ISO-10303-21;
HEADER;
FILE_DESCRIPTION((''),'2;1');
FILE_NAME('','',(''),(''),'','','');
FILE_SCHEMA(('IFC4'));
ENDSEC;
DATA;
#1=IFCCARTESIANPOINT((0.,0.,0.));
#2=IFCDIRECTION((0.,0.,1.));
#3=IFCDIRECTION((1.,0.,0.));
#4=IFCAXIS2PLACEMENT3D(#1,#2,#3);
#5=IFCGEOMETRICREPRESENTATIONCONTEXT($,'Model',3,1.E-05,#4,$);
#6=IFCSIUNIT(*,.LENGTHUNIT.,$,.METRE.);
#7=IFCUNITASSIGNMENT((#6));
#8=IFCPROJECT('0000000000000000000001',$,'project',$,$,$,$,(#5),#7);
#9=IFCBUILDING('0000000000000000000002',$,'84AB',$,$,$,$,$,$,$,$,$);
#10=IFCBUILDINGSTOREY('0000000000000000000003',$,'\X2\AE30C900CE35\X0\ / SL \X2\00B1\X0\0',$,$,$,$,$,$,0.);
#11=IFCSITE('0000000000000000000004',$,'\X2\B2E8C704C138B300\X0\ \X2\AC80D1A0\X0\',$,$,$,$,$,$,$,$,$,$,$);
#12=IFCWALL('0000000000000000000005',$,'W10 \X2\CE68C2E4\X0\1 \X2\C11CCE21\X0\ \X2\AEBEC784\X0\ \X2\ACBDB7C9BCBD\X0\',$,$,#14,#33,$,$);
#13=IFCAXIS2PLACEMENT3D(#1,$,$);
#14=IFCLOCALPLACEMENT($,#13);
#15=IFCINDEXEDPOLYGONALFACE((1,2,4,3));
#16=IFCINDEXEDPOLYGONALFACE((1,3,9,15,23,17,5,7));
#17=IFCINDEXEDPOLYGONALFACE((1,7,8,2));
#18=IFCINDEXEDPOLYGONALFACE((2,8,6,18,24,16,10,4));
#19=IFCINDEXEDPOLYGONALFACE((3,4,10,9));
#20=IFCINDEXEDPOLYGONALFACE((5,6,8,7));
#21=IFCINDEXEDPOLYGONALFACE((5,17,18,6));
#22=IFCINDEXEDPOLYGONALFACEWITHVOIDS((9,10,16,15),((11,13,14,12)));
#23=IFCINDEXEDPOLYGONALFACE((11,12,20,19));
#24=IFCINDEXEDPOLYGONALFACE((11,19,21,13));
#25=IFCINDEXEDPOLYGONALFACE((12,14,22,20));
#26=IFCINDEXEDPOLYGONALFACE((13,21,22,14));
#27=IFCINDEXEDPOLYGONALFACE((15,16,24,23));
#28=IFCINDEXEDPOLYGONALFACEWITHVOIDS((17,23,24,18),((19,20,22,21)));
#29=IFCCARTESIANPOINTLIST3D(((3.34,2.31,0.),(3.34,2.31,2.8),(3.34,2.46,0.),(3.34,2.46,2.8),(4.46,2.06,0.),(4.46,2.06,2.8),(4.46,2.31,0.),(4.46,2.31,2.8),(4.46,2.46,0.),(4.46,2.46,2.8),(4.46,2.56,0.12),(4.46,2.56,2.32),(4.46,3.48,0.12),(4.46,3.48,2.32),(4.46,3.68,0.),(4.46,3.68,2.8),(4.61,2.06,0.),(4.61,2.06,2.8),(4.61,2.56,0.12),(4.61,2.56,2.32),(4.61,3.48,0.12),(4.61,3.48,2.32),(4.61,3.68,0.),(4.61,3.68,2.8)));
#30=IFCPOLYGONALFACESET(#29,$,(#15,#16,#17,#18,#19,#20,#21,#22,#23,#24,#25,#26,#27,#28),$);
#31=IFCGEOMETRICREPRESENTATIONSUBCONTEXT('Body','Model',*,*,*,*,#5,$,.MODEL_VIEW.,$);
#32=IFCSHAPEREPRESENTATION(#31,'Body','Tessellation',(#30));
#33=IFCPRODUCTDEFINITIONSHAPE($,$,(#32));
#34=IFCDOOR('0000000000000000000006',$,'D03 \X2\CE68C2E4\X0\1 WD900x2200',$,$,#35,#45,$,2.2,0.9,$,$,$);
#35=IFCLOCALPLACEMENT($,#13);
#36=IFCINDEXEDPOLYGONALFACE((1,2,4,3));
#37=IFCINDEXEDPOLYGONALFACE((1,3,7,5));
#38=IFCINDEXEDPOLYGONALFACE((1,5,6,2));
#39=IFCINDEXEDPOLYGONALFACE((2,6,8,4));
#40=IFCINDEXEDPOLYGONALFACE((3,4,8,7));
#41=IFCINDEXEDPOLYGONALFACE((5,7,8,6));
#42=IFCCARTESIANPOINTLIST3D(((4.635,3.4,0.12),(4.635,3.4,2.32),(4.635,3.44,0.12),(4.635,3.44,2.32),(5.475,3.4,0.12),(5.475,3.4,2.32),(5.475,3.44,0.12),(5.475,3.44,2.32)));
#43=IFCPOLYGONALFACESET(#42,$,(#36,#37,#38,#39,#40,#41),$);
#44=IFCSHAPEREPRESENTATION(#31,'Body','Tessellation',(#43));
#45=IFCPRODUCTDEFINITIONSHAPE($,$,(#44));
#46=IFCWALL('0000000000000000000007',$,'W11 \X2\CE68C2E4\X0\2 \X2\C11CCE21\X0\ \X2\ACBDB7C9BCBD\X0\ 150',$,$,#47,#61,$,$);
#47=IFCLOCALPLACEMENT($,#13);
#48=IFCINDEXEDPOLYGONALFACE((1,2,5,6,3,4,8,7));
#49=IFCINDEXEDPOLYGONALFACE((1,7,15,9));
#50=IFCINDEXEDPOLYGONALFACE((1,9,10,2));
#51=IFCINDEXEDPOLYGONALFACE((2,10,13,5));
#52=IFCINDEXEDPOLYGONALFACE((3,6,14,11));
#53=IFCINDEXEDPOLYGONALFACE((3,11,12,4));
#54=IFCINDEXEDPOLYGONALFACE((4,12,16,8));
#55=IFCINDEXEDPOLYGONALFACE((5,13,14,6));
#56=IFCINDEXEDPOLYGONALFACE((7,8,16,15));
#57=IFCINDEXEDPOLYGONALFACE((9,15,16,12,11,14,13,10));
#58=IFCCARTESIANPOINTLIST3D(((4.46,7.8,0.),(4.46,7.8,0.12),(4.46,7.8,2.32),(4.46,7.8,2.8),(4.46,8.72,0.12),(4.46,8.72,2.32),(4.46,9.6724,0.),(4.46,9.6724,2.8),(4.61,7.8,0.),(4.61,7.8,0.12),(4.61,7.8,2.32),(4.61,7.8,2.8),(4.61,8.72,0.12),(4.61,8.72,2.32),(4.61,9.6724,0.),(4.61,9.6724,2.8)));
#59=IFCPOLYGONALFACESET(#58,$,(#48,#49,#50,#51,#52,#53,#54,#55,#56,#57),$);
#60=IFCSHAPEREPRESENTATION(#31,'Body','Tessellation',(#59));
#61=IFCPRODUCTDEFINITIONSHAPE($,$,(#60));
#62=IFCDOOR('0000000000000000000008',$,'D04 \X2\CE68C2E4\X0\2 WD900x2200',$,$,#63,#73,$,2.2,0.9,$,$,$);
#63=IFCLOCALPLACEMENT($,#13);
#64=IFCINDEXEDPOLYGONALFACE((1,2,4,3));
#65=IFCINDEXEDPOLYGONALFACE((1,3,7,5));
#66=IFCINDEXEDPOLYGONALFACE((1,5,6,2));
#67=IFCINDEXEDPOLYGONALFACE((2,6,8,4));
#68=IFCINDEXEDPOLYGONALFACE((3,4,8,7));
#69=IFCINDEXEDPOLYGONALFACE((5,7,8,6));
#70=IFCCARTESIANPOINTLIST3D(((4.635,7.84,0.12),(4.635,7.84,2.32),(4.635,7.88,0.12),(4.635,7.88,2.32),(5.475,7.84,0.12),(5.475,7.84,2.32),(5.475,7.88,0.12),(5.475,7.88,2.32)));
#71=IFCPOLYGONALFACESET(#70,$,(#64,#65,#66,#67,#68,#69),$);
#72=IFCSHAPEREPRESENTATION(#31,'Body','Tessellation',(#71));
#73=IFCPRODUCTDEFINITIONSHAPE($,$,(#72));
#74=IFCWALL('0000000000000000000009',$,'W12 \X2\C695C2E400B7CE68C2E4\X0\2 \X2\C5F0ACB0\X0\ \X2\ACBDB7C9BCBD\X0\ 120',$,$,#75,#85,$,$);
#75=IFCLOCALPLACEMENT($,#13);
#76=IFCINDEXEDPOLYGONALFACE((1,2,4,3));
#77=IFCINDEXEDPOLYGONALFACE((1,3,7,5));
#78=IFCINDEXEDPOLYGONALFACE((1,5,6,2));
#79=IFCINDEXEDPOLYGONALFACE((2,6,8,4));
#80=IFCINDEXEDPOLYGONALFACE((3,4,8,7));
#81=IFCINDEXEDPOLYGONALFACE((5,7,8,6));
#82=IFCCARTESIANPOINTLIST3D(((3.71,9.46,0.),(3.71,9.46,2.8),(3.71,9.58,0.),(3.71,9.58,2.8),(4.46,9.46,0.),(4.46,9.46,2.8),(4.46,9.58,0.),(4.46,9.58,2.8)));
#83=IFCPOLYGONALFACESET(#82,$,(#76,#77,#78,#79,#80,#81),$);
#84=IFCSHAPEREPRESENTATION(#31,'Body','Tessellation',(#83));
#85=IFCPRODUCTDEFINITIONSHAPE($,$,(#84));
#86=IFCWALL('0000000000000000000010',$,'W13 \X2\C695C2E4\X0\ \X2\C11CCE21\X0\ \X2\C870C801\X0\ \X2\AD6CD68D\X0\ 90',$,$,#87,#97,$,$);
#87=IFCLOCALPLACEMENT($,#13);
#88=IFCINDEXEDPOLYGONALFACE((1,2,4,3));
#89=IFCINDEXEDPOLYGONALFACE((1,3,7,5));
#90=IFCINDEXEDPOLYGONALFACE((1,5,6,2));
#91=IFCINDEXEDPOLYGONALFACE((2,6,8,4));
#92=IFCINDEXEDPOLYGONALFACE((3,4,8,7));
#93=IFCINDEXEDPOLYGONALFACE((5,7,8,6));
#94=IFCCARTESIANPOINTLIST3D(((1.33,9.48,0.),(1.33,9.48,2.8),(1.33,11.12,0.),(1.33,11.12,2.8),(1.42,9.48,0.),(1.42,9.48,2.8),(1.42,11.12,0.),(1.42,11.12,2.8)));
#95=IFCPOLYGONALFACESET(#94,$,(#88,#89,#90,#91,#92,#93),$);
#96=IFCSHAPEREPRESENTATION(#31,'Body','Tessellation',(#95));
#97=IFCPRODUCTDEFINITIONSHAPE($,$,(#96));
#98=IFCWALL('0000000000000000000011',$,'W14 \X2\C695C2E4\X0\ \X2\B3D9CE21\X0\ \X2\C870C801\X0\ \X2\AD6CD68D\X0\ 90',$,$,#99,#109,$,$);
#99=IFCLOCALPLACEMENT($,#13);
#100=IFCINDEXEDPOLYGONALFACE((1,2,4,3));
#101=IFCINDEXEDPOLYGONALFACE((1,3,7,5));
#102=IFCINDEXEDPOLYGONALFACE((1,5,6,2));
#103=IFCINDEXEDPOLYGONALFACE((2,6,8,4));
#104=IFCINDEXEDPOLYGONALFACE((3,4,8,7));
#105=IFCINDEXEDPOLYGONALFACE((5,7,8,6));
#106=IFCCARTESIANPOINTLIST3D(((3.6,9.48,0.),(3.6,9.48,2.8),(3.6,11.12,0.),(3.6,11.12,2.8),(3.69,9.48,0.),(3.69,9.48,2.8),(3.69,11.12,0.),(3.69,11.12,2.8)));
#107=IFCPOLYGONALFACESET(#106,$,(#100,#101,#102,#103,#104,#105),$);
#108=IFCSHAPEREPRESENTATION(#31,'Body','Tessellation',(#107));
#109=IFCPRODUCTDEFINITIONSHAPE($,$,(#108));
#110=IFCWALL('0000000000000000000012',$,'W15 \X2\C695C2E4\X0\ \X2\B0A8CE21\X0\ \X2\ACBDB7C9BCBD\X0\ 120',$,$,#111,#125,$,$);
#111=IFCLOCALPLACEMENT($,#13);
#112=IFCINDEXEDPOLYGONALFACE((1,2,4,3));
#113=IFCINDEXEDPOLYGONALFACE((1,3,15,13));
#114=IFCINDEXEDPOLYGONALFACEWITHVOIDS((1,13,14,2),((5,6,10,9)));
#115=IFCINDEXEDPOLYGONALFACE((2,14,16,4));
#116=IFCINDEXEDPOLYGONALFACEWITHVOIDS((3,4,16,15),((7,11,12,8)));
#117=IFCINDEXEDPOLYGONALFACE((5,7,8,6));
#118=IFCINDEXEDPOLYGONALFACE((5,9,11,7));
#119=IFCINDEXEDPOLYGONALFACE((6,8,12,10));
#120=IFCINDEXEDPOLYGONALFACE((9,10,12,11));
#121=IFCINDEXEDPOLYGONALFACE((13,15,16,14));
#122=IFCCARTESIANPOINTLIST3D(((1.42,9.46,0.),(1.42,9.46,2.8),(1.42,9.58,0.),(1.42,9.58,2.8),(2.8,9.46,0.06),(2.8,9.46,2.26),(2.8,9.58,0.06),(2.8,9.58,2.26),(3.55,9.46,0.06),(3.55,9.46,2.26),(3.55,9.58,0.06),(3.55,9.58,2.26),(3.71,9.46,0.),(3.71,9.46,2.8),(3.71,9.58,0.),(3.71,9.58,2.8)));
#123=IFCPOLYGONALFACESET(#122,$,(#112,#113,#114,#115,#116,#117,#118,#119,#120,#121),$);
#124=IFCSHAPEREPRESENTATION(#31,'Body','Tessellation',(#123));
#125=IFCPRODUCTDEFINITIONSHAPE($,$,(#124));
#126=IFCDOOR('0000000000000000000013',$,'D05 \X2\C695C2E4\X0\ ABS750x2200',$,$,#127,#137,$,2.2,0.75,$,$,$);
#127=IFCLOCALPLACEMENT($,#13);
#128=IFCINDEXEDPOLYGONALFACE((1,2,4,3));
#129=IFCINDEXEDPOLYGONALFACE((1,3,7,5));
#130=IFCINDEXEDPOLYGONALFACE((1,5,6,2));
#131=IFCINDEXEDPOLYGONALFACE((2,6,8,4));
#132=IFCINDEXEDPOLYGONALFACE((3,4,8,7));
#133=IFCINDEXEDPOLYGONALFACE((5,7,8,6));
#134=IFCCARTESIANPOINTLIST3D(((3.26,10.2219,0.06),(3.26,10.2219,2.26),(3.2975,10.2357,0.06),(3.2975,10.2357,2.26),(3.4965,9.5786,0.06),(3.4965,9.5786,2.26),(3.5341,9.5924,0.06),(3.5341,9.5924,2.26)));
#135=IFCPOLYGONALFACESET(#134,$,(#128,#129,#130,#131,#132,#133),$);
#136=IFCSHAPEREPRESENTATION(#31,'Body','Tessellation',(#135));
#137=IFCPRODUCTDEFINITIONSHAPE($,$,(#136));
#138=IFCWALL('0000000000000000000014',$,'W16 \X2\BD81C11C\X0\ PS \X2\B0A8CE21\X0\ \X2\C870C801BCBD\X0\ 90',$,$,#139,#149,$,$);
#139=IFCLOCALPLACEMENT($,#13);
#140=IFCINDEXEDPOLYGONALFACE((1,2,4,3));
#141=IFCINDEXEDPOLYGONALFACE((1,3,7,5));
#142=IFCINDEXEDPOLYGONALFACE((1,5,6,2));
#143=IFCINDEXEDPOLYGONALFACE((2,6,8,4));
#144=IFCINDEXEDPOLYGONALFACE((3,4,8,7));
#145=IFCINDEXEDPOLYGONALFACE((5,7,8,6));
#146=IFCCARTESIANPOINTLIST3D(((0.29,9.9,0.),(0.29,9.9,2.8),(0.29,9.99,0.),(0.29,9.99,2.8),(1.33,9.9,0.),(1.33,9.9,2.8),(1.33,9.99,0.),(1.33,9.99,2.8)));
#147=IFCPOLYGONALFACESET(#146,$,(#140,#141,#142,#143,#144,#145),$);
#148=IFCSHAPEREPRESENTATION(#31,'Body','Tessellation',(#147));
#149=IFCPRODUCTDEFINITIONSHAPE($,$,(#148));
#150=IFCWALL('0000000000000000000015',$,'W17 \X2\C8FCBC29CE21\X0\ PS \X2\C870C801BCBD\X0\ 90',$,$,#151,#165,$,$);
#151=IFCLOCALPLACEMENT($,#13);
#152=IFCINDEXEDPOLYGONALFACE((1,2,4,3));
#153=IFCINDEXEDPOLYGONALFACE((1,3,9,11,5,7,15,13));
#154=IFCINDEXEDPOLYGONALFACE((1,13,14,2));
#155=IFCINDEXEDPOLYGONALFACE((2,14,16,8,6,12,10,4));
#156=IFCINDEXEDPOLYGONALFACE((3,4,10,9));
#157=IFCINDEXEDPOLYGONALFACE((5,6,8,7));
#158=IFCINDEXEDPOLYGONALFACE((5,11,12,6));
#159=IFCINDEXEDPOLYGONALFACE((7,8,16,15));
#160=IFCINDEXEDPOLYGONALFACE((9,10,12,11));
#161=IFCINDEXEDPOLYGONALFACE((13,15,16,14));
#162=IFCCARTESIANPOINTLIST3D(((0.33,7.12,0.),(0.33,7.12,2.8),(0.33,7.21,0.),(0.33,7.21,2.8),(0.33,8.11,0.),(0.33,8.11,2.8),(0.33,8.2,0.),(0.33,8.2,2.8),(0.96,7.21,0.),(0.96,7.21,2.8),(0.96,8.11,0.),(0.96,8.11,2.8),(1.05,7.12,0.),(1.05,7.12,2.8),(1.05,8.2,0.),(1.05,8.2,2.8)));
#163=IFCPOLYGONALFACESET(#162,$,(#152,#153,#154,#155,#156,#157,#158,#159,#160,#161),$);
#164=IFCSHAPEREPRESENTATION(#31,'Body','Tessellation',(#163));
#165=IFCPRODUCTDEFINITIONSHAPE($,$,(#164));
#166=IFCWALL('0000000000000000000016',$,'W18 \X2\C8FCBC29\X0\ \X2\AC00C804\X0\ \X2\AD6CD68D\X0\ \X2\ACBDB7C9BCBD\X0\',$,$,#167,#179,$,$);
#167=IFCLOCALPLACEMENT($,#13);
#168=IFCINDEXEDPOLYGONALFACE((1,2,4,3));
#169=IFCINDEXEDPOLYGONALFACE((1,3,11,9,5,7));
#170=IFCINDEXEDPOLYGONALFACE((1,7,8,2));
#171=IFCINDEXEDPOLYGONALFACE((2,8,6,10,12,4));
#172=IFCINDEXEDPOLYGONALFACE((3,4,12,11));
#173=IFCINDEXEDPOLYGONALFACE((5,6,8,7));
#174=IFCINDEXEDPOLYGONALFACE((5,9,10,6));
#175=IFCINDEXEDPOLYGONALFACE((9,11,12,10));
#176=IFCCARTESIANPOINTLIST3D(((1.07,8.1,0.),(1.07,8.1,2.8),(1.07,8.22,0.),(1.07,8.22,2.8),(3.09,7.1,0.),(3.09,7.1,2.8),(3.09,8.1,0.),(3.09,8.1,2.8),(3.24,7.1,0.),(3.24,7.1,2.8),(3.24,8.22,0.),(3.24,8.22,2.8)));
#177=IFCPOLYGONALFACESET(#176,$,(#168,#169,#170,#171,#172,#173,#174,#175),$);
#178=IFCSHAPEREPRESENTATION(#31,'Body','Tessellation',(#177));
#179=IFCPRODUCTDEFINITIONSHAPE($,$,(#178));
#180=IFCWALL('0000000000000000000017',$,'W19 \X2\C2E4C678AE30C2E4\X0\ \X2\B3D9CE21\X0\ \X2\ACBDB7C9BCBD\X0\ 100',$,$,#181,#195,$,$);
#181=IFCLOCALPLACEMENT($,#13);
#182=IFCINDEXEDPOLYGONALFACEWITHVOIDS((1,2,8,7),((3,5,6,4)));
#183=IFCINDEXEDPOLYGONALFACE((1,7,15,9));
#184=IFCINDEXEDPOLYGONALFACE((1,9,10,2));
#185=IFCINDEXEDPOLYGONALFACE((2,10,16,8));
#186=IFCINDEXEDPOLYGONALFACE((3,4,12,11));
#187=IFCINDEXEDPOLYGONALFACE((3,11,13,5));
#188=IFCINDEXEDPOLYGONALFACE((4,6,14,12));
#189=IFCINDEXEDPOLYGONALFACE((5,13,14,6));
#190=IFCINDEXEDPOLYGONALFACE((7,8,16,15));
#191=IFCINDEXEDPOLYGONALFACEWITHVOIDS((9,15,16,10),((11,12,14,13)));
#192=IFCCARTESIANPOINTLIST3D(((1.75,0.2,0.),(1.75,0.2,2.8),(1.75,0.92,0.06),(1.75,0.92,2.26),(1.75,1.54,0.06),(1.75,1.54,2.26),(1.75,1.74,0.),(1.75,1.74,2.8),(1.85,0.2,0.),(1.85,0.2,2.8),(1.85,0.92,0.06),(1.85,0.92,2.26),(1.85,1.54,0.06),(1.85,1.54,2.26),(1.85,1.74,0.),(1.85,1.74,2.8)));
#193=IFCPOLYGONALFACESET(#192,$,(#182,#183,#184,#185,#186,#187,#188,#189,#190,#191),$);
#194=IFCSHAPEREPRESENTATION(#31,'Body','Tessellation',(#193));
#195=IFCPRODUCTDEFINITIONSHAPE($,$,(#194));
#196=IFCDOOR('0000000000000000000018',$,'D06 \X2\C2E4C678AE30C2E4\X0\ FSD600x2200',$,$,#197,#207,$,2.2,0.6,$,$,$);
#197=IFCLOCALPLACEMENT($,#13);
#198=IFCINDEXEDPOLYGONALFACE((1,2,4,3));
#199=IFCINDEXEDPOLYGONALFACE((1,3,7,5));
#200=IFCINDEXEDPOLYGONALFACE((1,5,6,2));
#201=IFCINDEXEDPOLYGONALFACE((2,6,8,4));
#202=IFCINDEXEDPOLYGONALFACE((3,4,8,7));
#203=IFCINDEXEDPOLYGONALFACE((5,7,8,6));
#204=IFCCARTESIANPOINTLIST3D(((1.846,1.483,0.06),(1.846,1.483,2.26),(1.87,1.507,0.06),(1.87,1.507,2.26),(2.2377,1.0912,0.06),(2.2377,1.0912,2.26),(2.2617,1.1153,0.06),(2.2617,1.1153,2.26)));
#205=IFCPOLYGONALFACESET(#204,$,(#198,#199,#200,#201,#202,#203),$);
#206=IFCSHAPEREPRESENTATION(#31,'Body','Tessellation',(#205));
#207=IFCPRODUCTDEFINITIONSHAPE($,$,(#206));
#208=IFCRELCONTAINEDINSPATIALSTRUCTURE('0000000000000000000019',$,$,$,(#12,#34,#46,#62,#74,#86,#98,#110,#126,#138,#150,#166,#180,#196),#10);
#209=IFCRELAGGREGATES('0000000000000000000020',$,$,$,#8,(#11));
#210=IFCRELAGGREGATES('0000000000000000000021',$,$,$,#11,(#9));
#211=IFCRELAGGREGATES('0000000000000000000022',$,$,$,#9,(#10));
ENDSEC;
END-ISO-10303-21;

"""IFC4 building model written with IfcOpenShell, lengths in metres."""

from ifc_helpers import new_model, si_unit, frame, origin, origin_with_axes, place, context, subcontext, project, spatial, polyline, outline, extrude, element, fill, save


model = new_model("IFC4")

# Units and contexts
model_context = context("Model", 3, precision=1e-05, world=origin_with_axes())
body_context = subcontext(model_context, "Body", "Model", "MODEL_VIEW")
ifc_project = project(units=[si_unit("LENGTHUNIT", "METRE")], contexts=[model_context])

# Site, building, storey
site = spatial("IfcSite", under=ifc_project, Name="단위세대 검토")
building = spatial("IfcBuilding", under=site, Name="84AB")
storey = spatial("IfcBuildingStorey", under=building, Name="기준층 / SL ±0", Elevation=0.0)

# Walls, openings, doors
wall_1_placement = place(None, origin_with_axes())
wall_1 = element("IfcWall", 1, at=wall_1_placement, inside=storey, Name="W10 침실1 서측 꺾임 경량벽", context=body_context, shape_type="SweptSolid", body=[
    extrude(outline(polyline([(4.61, 2.31), (4.61, 2.06), (4.46, 2.06), (4.46, 2.31), (3.34, 2.31), (3.34, 2.46), (4.46, 2.46), (4.46, 3.68), (4.61, 3.68), (4.61, 2.46), (4.61, 2.31)])), origin(), (0.0, 0.0, 1.0), 2.8),
])
opening_1_placement = place(wall_1_placement, origin_with_axes())
opening_1 = element("IfcOpeningElement", 2, at=opening_1_placement, cuts=wall_1, context=body_context, shape_type="SweptSolid", body=[
    extrude(outline(polyline([(4.611, 2.56), (4.611, 3.48), (4.459, 3.48), (4.459, 2.56), (4.611, 2.56)])), frame((0.0, 0.0, 0.12)), (0.0, 0.0, 1.0), 2.2),
])
door_1_placement = place(None, origin_with_axes())
door_1 = element("IfcDoor", 3, at=door_1_placement, inside=storey, Name="D03 침실1 WD900x2200", OverallHeight=2.2, OverallWidth=0.9, context=body_context, shape_type="SweptSolid", body=[
    extrude(outline(polyline([(4.635, 3.4), (4.635, 3.44), (5.475, 3.44), (5.475, 3.4), (4.635, 3.4)])), frame((0.0, 0.0, 0.12)), (0.0, 0.0, 1.0), 2.2),
])
fill(opening_1, door_1)
wall_2_placement = place(None, origin_with_axes())
wall_2 = element("IfcWall", 4, at=wall_2_placement, inside=storey, Name="W11 침실2 서측 경량벽 150", context=body_context, shape_type="SweptSolid", body=[
    extrude(outline(polyline([(4.61, 7.8), (4.61, 9.6724), (4.46, 9.6724), (4.46, 7.8), (4.61, 7.8)])), origin(), (0.0, 0.0, 1.0), 2.8),
])
opening_2_placement = place(wall_2_placement, origin_with_axes())
opening_2 = element("IfcOpeningElement", 5, at=opening_2_placement, cuts=wall_2, context=body_context, shape_type="SweptSolid", body=[
    extrude(outline(polyline([(4.611, 7.8), (4.611, 8.72), (4.459, 8.72), (4.459, 7.8), (4.611, 7.8)])), frame((0.0, 0.0, 0.12)), (0.0, 0.0, 1.0), 2.2),
])
door_2_placement = place(None, origin_with_axes())
door_2 = element("IfcDoor", 6, at=door_2_placement, inside=storey, Name="D04 침실2 WD900x2200", OverallHeight=2.2, OverallWidth=0.9, context=body_context, shape_type="SweptSolid", body=[
    extrude(outline(polyline([(4.635, 7.88), (4.635, 7.84), (5.475, 7.84), (5.475, 7.88), (4.635, 7.88)])), frame((0.0, 0.0, 0.12)), (0.0, 0.0, 1.0), 2.2),
])
fill(opening_2, door_2)

# Walls
wall_3_placement = place(None, origin_with_axes())
element("IfcWall", 7, at=wall_3_placement, inside=storey, Name="W12 욕실·침실2 연결 경량벽 120", context=body_context, shape_type="SweptSolid", body=[
    extrude(outline(polyline([(4.46, 9.46), (4.46, 9.58), (3.71, 9.58), (3.71, 9.46), (4.46, 9.46)])), origin(), (0.0, 0.0, 1.0), 2.8),
])
wall_4_placement = place(None, origin_with_axes())
element("IfcWall", 8, at=wall_4_placement, inside=storey, Name="W13 욕실 서측 조적 구획 90", context=body_context, shape_type="SweptSolid", body=[
    extrude(outline(polyline([(1.42, 9.48), (1.42, 11.12), (1.33, 11.12), (1.33, 9.48), (1.42, 9.48)])), origin(), (0.0, 0.0, 1.0), 2.8),
])
wall_5_placement = place(None, origin_with_axes())
element("IfcWall", 9, at=wall_5_placement, inside=storey, Name="W14 욕실 동측 조적 구획 90", context=body_context, shape_type="SweptSolid", body=[
    extrude(outline(polyline([(3.69, 9.48), (3.69, 11.12), (3.6, 11.12), (3.6, 9.48), (3.69, 9.48)])), origin(), (0.0, 0.0, 1.0), 2.8),
])

# Wall, opening, door
wall_6_placement = place(None, origin_with_axes())
wall_6 = element("IfcWall", 10, at=wall_6_placement, inside=storey, Name="W15 욕실 남측 경량벽 120", context=body_context, shape_type="SweptSolid", body=[
    extrude(outline(polyline([(3.71, 9.46), (3.71, 9.58), (1.42, 9.58), (1.42, 9.46), (3.71, 9.46)])), origin(), (0.0, 0.0, 1.0), 2.8),
])
opening_3_placement = place(wall_6_placement, origin_with_axes())
opening_3 = element("IfcOpeningElement", 11, at=opening_3_placement, cuts=wall_6, context=body_context, shape_type="SweptSolid", body=[
    extrude(outline(polyline([(3.55, 9.459), (3.55, 9.581), (2.8, 9.581), (2.8, 9.459), (3.55, 9.459)])), frame((0.0, 0.0, 0.06)), (0.0, 0.0, 1.0), 2.2),
])
door_3_placement = place(None, origin_with_axes())
door_3 = element("IfcDoor", 12, at=door_3_placement, inside=storey, Name="D05 욕실 ABS750x2200", OverallHeight=2.2, OverallWidth=0.75, context=body_context, shape_type="SweptSolid", body=[
    extrude(outline(polyline([(3.26, 10.2219), (3.2975, 10.2357), (3.5341, 9.5924), (3.4965, 9.5786), (3.26, 10.2219)])), frame((0.0, 0.0, 0.06)), (0.0, 0.0, 1.0), 2.2),
])
fill(opening_3, door_3)

# Walls
wall_7_placement = place(None, origin_with_axes())
element("IfcWall", 13, at=wall_7_placement, inside=storey, Name="W16 북서 PS 남측 조적벽 90", context=body_context, shape_type="SweptSolid", body=[
    extrude(outline(polyline([(1.33, 9.9), (1.33, 9.99), (0.29, 9.99), (0.29, 9.9), (1.33, 9.9)])), origin(), (0.0, 0.0, 1.0), 2.8),
])
wall_8_placement = place(None, origin_with_axes())
element("IfcWall", 14, at=wall_8_placement, inside=storey, Name="W17 주방측 PS 조적벽 90", context=body_context, shape_type="SweptSolid", body=[
    extrude(outline(polyline([(0.33, 7.12), (1.05, 7.12), (1.05, 8.2), (0.33, 8.2), (0.33, 8.11), (0.96, 8.11), (0.96, 7.21), (0.33, 7.21), (0.33, 7.12)])), origin(), (0.0, 0.0, 1.0), 2.8),
])
wall_9_placement = place(None, origin_with_axes())
element("IfcWall", 15, at=wall_9_placement, inside=storey, Name="W18 주방 가전 구획 경량벽", context=body_context, shape_type="SweptSolid", body=[
    extrude(outline(polyline([(1.07, 8.1), (3.09, 8.1), (3.09, 7.1), (3.24, 7.1), (3.24, 8.22), (1.07, 8.22), (1.07, 8.1)])), origin(), (0.0, 0.0, 1.0), 2.8),
])

# Wall, opening, door
wall_10_placement = place(None, origin_with_axes())
wall_10 = element("IfcWall", 16, at=wall_10_placement, inside=storey, Name="W19 실외기실 동측 경량벽 100", context=body_context, shape_type="SweptSolid", body=[
    extrude(outline(polyline([(1.85, 0.2), (1.85, 1.74), (1.75, 1.74), (1.75, 0.2), (1.85, 0.2)])), origin(), (0.0, 0.0, 1.0), 2.8),
])
opening_4_placement = place(wall_10_placement, origin_with_axes())
opening_4 = element("IfcOpeningElement", 17, at=opening_4_placement, cuts=wall_10, context=body_context, shape_type="SweptSolid", body=[
    extrude(outline(polyline([(1.851, 0.92), (1.851, 1.54), (1.749, 1.54), (1.749, 0.92), (1.851, 0.92)])), frame((0.0, 0.0, 0.06)), (0.0, 0.0, 1.0), 2.2),
])
door_4_placement = place(None, origin_with_axes())
door_4 = element("IfcDoor", 18, at=door_4_placement, inside=storey, Name="D06 실외기실 FSD600x2200", OverallHeight=2.2, OverallWidth=0.6, context=body_context, shape_type="SweptSolid", body=[
    extrude(outline(polyline([(1.846, 1.483), (1.87, 1.507), (2.2617, 1.1153), (2.2377, 1.0912), (1.846, 1.483)])), frame((0.0, 0.0, 0.06)), (0.0, 0.0, 1.0), 2.2),
])
fill(opening_4, door_4)

save(model, "model.ifc")
